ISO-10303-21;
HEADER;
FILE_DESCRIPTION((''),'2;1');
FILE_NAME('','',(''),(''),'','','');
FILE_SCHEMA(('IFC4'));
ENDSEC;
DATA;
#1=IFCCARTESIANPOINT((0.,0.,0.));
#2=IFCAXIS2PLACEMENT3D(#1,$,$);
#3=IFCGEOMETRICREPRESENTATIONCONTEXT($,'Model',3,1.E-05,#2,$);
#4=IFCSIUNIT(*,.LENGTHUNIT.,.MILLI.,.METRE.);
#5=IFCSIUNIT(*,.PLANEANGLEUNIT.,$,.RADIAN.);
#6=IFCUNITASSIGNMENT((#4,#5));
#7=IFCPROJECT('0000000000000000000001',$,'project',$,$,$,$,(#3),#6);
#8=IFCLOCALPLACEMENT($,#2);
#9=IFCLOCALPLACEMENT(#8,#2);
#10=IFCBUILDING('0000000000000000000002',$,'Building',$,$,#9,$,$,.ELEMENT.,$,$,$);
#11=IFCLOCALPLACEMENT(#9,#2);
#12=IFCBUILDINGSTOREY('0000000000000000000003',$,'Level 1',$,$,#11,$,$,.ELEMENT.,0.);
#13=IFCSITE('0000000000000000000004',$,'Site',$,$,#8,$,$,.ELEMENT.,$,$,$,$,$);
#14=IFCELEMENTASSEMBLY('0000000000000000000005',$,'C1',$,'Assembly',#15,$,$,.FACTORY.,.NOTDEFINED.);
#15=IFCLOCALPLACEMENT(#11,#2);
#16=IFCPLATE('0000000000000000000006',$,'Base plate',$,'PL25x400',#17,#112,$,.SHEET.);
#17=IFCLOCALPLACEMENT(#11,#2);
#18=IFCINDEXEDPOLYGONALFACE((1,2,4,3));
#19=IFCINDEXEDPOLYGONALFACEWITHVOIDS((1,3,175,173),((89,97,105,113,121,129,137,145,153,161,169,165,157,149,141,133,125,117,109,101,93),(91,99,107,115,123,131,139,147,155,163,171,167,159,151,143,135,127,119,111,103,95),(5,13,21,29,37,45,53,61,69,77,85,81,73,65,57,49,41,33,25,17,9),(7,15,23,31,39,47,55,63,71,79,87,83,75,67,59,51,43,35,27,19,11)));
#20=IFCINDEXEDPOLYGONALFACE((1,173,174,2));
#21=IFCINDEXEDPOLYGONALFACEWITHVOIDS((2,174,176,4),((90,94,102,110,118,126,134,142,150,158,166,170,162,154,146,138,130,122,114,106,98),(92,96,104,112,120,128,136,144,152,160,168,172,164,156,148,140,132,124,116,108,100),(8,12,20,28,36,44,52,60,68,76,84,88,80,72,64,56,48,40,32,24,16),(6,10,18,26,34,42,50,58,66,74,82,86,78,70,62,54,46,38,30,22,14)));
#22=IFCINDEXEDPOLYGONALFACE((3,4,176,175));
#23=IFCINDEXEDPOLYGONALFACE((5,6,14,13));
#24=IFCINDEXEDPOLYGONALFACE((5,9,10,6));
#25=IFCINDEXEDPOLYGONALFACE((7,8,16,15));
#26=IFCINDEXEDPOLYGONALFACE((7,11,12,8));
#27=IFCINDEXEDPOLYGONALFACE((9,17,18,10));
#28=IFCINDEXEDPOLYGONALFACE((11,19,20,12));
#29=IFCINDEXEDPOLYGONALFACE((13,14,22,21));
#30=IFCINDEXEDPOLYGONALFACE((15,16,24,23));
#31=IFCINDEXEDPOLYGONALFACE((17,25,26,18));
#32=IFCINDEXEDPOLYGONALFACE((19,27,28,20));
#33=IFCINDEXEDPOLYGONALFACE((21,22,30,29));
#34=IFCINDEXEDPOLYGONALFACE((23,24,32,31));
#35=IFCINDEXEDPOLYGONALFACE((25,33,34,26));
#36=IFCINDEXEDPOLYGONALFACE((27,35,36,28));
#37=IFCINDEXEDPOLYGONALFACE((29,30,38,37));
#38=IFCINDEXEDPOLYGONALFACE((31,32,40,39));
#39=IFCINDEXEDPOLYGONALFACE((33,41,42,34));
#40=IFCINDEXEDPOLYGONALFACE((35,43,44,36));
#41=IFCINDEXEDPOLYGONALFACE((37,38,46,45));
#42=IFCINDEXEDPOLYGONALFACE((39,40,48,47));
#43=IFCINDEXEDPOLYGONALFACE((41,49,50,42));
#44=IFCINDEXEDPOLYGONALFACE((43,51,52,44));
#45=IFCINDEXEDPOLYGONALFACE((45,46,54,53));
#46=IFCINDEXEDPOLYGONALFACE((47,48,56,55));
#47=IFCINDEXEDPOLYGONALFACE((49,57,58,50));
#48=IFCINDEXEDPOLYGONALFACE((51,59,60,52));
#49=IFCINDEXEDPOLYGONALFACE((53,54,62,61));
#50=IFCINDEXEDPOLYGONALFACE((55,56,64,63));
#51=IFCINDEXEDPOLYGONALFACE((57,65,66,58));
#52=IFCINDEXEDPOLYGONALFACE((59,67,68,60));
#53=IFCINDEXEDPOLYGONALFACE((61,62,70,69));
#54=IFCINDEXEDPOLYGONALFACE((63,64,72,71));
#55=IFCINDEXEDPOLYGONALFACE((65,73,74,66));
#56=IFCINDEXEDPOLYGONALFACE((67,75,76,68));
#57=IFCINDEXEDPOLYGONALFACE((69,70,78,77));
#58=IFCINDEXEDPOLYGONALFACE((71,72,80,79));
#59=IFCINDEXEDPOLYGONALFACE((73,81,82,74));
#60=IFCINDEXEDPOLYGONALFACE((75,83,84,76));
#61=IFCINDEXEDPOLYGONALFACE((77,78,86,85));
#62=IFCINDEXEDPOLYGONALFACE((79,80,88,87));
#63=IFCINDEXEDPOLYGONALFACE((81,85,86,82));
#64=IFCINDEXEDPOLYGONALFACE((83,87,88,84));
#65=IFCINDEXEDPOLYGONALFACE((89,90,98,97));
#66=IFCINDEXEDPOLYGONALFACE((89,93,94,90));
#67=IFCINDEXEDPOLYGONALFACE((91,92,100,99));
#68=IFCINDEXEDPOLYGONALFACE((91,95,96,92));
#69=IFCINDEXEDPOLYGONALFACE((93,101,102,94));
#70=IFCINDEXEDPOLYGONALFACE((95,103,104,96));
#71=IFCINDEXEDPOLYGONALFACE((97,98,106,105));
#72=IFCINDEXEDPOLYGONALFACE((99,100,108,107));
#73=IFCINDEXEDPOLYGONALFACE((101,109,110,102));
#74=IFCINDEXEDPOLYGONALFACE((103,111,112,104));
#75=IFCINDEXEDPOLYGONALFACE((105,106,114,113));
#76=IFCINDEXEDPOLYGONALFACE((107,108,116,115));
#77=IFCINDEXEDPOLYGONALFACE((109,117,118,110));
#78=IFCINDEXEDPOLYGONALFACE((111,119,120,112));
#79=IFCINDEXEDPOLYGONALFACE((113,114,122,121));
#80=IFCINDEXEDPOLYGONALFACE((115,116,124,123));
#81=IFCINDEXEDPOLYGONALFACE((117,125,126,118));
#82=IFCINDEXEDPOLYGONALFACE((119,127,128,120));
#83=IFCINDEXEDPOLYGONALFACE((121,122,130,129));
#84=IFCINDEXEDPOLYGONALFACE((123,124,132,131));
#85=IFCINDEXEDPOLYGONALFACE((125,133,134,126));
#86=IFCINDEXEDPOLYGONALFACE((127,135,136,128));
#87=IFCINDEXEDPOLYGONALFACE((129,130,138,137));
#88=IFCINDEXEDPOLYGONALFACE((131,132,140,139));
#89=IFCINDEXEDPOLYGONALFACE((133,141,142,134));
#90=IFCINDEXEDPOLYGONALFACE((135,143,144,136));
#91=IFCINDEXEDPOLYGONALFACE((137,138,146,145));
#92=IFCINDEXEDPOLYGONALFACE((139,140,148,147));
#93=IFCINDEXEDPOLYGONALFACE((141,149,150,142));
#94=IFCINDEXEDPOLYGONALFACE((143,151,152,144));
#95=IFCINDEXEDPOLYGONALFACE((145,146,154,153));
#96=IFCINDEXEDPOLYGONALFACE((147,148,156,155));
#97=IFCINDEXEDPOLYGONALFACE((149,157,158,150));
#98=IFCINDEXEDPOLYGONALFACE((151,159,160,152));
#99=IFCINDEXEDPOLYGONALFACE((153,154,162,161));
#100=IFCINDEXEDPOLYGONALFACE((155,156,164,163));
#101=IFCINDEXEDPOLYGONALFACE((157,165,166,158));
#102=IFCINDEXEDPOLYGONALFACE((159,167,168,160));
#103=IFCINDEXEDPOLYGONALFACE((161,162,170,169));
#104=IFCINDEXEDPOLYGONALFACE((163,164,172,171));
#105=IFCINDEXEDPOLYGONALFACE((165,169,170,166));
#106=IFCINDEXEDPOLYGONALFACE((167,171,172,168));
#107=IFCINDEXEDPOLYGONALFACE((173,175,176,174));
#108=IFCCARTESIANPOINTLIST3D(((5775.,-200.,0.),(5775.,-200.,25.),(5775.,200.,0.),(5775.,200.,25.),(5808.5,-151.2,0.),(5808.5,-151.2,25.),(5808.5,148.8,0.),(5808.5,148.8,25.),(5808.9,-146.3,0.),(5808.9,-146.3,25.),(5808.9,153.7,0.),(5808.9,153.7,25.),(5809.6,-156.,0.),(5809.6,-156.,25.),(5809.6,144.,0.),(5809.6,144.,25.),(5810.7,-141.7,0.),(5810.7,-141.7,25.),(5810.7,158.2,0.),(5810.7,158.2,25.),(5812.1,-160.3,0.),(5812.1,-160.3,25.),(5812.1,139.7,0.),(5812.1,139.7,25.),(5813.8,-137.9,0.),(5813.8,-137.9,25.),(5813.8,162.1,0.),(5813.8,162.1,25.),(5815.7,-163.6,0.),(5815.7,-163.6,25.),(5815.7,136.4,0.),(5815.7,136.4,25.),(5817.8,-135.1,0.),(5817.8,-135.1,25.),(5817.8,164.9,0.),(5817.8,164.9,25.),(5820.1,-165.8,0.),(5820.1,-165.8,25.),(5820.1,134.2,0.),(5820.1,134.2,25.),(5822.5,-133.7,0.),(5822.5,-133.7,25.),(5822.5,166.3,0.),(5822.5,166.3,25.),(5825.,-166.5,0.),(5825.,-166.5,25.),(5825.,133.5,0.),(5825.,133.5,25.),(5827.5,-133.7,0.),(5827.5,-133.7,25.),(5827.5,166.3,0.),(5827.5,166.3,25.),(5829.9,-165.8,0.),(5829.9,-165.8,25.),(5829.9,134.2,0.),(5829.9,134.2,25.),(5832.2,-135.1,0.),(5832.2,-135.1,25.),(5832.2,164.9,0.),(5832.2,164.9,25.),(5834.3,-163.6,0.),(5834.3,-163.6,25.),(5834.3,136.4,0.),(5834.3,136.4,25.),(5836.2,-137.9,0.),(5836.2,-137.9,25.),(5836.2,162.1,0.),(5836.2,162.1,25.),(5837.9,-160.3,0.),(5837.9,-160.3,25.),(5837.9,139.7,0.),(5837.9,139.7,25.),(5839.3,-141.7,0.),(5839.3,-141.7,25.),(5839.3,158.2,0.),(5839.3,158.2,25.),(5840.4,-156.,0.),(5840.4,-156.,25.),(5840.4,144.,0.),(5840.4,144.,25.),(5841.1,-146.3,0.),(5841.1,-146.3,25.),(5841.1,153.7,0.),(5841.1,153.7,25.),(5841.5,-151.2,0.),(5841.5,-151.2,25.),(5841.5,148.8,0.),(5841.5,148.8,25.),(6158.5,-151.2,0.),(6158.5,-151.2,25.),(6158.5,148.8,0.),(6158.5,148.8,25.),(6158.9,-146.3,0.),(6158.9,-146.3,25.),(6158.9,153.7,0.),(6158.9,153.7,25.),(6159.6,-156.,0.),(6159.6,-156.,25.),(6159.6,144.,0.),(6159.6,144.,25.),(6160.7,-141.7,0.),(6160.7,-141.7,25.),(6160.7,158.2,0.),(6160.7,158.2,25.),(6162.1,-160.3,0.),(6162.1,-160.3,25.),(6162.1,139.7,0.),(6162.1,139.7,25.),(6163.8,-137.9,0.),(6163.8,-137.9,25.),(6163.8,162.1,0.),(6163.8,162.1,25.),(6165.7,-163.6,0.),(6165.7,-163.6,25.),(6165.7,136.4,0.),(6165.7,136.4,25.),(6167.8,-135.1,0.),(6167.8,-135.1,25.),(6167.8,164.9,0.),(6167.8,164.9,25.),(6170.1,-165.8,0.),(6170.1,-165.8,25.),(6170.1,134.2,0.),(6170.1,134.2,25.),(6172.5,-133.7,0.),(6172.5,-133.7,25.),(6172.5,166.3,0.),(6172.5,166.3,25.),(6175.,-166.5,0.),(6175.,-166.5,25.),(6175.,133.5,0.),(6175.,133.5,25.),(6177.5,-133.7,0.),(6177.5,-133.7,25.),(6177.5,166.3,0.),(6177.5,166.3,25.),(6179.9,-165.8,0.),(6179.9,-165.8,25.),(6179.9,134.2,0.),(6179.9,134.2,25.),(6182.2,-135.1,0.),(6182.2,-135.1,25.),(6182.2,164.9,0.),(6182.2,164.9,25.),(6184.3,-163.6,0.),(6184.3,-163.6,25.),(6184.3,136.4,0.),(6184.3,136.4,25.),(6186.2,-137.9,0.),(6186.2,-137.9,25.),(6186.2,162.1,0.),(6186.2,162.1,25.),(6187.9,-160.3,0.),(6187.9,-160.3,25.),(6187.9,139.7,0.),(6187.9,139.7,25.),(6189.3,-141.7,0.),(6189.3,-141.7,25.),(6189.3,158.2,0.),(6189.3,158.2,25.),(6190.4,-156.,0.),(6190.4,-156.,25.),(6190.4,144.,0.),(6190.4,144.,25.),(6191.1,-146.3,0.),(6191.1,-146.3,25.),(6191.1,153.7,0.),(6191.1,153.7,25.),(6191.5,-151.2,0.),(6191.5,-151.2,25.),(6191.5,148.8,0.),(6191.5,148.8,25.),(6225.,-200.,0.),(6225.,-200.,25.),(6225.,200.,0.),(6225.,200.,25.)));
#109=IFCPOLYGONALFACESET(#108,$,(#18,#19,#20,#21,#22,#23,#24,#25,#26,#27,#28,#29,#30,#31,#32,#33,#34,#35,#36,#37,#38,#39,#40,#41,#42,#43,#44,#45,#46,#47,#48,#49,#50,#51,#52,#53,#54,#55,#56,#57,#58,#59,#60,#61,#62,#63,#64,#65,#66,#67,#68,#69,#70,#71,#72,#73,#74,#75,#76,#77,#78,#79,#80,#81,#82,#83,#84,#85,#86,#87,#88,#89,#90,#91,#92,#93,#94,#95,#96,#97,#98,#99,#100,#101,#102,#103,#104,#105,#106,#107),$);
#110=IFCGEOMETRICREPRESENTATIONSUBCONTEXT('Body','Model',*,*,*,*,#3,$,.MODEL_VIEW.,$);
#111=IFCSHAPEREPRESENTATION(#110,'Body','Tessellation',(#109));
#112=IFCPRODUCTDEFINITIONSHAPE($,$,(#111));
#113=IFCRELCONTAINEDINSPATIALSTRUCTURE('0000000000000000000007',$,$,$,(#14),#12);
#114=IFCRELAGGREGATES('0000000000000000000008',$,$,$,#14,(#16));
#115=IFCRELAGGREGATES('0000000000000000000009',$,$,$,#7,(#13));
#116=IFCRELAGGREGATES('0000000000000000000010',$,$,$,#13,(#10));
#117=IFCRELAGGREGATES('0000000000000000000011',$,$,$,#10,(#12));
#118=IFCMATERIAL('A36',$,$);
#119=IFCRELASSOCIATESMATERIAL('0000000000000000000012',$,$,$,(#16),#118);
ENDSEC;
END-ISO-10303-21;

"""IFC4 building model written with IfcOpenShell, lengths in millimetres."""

from ifc_helpers import new_model, si_unit, frame, origin, origin_2d, place, context, subcontext, project, spatial, rectangle, circle, extrude, material, element, aggregate, save


model = new_model("IFC4")

# Units and contexts
model_context = context("Model", 3, precision=1e-05, world=origin())
body_context = subcontext(model_context, "Body", "Model", "MODEL_VIEW")
ifc_project = project(units=[si_unit("LENGTHUNIT", "METRE", prefix="MILLI"), si_unit("PLANEANGLEUNIT", "RADIAN")], contexts=[model_context])

# Site, building, storey
site_placement = place(None, origin())
site = spatial("IfcSite", under=ifc_project, at=site_placement, Name="Site", CompositionType="ELEMENT")
building_placement = place(site_placement, origin())
building = spatial("IfcBuilding", under=site, at=building_placement, Name="Building", CompositionType="ELEMENT")
storey_placement = place(building_placement, origin())
storey = spatial("IfcBuildingStorey", under=building, at=storey_placement, Name="Level 1", CompositionType="ELEMENT", Elevation=0.0)

# Element assembly, plate, openings
assembly_1_placement = place(storey_placement, origin())
assembly_1 = element("IfcElementAssembly", 1, at=assembly_1_placement, inside=storey, Name="C1", ObjectType="Assembly", AssemblyPlace="FACTORY", PredefinedType="NOTDEFINED")
ifc_material = material(Name="A36")
plate_1_placement = place(storey_placement, frame((5775.0, 0.0, 12.5), z_axis=(1.0, 0.0, 0.0), x_axis=(0.0, 1.0, 0.0)))
plate_1 = element("IfcPlate", 2, at=plate_1_placement, material=ifc_material, Name="Base plate", ObjectType="PL25x400", PredefinedType="SHEET", context=body_context, shape_type="SweptSolid", body=[
    extrude(rectangle(XDim=400.0, YDim=25.0, at=origin_2d()), origin(), (0.0, 0.0, 1.0), 450.0),
])
opening_1_placement = place(plate_1_placement, frame((-150.0, -13.5, 50.0), z_axis=(0.0, 1.0, 0.0), x_axis=(-1.0, 0.0, 0.0)))
element("IfcOpeningElement", 3, at=opening_1_placement, cuts=plate_1, PredefinedType="OPENING", context=body_context, shape_type="SweptSolid", body=[
    extrude(circle(Radius=16.5, at=origin_2d()), origin(), (0.0, 0.0, 1.0), 27.0),
])
opening_2_placement = place(plate_1_placement, frame((150.0, -13.5, 50.0), z_axis=(0.0, 1.0, 0.0), x_axis=(-1.0, 0.0, 0.0)))
element("IfcOpeningElement", 4, at=opening_2_placement, cuts=plate_1, PredefinedType="OPENING", context=body_context, shape_type="SweptSolid", body=[
    extrude(circle(Radius=16.5, at=origin_2d()), origin(), (0.0, 0.0, 1.0), 27.0),
])
opening_3_placement = place(plate_1_placement, frame((-150.0, -13.5, 400.0), z_axis=(0.0, 1.0, 0.0), x_axis=(-1.0, 0.0, 0.0)))
element("IfcOpeningElement", 5, at=opening_3_placement, cuts=plate_1, PredefinedType="OPENING", context=body_context, shape_type="SweptSolid", body=[
    extrude(circle(Radius=16.5, at=origin_2d()), origin(), (0.0, 0.0, 1.0), 27.0),
])
opening_4_placement = place(plate_1_placement, frame((150.0, -13.5, 400.0), z_axis=(0.0, 1.0, 0.0), x_axis=(-1.0, 0.0, 0.0)))
element("IfcOpeningElement", 6, at=opening_4_placement, cuts=plate_1, PredefinedType="OPENING", context=body_context, shape_type="SweptSolid", body=[
    extrude(circle(Radius=16.5, at=origin_2d()), origin(), (0.0, 0.0, 1.0), 27.0),
])
aggregate(assembly_1, [plate_1])

save(model, "model.ifc")
